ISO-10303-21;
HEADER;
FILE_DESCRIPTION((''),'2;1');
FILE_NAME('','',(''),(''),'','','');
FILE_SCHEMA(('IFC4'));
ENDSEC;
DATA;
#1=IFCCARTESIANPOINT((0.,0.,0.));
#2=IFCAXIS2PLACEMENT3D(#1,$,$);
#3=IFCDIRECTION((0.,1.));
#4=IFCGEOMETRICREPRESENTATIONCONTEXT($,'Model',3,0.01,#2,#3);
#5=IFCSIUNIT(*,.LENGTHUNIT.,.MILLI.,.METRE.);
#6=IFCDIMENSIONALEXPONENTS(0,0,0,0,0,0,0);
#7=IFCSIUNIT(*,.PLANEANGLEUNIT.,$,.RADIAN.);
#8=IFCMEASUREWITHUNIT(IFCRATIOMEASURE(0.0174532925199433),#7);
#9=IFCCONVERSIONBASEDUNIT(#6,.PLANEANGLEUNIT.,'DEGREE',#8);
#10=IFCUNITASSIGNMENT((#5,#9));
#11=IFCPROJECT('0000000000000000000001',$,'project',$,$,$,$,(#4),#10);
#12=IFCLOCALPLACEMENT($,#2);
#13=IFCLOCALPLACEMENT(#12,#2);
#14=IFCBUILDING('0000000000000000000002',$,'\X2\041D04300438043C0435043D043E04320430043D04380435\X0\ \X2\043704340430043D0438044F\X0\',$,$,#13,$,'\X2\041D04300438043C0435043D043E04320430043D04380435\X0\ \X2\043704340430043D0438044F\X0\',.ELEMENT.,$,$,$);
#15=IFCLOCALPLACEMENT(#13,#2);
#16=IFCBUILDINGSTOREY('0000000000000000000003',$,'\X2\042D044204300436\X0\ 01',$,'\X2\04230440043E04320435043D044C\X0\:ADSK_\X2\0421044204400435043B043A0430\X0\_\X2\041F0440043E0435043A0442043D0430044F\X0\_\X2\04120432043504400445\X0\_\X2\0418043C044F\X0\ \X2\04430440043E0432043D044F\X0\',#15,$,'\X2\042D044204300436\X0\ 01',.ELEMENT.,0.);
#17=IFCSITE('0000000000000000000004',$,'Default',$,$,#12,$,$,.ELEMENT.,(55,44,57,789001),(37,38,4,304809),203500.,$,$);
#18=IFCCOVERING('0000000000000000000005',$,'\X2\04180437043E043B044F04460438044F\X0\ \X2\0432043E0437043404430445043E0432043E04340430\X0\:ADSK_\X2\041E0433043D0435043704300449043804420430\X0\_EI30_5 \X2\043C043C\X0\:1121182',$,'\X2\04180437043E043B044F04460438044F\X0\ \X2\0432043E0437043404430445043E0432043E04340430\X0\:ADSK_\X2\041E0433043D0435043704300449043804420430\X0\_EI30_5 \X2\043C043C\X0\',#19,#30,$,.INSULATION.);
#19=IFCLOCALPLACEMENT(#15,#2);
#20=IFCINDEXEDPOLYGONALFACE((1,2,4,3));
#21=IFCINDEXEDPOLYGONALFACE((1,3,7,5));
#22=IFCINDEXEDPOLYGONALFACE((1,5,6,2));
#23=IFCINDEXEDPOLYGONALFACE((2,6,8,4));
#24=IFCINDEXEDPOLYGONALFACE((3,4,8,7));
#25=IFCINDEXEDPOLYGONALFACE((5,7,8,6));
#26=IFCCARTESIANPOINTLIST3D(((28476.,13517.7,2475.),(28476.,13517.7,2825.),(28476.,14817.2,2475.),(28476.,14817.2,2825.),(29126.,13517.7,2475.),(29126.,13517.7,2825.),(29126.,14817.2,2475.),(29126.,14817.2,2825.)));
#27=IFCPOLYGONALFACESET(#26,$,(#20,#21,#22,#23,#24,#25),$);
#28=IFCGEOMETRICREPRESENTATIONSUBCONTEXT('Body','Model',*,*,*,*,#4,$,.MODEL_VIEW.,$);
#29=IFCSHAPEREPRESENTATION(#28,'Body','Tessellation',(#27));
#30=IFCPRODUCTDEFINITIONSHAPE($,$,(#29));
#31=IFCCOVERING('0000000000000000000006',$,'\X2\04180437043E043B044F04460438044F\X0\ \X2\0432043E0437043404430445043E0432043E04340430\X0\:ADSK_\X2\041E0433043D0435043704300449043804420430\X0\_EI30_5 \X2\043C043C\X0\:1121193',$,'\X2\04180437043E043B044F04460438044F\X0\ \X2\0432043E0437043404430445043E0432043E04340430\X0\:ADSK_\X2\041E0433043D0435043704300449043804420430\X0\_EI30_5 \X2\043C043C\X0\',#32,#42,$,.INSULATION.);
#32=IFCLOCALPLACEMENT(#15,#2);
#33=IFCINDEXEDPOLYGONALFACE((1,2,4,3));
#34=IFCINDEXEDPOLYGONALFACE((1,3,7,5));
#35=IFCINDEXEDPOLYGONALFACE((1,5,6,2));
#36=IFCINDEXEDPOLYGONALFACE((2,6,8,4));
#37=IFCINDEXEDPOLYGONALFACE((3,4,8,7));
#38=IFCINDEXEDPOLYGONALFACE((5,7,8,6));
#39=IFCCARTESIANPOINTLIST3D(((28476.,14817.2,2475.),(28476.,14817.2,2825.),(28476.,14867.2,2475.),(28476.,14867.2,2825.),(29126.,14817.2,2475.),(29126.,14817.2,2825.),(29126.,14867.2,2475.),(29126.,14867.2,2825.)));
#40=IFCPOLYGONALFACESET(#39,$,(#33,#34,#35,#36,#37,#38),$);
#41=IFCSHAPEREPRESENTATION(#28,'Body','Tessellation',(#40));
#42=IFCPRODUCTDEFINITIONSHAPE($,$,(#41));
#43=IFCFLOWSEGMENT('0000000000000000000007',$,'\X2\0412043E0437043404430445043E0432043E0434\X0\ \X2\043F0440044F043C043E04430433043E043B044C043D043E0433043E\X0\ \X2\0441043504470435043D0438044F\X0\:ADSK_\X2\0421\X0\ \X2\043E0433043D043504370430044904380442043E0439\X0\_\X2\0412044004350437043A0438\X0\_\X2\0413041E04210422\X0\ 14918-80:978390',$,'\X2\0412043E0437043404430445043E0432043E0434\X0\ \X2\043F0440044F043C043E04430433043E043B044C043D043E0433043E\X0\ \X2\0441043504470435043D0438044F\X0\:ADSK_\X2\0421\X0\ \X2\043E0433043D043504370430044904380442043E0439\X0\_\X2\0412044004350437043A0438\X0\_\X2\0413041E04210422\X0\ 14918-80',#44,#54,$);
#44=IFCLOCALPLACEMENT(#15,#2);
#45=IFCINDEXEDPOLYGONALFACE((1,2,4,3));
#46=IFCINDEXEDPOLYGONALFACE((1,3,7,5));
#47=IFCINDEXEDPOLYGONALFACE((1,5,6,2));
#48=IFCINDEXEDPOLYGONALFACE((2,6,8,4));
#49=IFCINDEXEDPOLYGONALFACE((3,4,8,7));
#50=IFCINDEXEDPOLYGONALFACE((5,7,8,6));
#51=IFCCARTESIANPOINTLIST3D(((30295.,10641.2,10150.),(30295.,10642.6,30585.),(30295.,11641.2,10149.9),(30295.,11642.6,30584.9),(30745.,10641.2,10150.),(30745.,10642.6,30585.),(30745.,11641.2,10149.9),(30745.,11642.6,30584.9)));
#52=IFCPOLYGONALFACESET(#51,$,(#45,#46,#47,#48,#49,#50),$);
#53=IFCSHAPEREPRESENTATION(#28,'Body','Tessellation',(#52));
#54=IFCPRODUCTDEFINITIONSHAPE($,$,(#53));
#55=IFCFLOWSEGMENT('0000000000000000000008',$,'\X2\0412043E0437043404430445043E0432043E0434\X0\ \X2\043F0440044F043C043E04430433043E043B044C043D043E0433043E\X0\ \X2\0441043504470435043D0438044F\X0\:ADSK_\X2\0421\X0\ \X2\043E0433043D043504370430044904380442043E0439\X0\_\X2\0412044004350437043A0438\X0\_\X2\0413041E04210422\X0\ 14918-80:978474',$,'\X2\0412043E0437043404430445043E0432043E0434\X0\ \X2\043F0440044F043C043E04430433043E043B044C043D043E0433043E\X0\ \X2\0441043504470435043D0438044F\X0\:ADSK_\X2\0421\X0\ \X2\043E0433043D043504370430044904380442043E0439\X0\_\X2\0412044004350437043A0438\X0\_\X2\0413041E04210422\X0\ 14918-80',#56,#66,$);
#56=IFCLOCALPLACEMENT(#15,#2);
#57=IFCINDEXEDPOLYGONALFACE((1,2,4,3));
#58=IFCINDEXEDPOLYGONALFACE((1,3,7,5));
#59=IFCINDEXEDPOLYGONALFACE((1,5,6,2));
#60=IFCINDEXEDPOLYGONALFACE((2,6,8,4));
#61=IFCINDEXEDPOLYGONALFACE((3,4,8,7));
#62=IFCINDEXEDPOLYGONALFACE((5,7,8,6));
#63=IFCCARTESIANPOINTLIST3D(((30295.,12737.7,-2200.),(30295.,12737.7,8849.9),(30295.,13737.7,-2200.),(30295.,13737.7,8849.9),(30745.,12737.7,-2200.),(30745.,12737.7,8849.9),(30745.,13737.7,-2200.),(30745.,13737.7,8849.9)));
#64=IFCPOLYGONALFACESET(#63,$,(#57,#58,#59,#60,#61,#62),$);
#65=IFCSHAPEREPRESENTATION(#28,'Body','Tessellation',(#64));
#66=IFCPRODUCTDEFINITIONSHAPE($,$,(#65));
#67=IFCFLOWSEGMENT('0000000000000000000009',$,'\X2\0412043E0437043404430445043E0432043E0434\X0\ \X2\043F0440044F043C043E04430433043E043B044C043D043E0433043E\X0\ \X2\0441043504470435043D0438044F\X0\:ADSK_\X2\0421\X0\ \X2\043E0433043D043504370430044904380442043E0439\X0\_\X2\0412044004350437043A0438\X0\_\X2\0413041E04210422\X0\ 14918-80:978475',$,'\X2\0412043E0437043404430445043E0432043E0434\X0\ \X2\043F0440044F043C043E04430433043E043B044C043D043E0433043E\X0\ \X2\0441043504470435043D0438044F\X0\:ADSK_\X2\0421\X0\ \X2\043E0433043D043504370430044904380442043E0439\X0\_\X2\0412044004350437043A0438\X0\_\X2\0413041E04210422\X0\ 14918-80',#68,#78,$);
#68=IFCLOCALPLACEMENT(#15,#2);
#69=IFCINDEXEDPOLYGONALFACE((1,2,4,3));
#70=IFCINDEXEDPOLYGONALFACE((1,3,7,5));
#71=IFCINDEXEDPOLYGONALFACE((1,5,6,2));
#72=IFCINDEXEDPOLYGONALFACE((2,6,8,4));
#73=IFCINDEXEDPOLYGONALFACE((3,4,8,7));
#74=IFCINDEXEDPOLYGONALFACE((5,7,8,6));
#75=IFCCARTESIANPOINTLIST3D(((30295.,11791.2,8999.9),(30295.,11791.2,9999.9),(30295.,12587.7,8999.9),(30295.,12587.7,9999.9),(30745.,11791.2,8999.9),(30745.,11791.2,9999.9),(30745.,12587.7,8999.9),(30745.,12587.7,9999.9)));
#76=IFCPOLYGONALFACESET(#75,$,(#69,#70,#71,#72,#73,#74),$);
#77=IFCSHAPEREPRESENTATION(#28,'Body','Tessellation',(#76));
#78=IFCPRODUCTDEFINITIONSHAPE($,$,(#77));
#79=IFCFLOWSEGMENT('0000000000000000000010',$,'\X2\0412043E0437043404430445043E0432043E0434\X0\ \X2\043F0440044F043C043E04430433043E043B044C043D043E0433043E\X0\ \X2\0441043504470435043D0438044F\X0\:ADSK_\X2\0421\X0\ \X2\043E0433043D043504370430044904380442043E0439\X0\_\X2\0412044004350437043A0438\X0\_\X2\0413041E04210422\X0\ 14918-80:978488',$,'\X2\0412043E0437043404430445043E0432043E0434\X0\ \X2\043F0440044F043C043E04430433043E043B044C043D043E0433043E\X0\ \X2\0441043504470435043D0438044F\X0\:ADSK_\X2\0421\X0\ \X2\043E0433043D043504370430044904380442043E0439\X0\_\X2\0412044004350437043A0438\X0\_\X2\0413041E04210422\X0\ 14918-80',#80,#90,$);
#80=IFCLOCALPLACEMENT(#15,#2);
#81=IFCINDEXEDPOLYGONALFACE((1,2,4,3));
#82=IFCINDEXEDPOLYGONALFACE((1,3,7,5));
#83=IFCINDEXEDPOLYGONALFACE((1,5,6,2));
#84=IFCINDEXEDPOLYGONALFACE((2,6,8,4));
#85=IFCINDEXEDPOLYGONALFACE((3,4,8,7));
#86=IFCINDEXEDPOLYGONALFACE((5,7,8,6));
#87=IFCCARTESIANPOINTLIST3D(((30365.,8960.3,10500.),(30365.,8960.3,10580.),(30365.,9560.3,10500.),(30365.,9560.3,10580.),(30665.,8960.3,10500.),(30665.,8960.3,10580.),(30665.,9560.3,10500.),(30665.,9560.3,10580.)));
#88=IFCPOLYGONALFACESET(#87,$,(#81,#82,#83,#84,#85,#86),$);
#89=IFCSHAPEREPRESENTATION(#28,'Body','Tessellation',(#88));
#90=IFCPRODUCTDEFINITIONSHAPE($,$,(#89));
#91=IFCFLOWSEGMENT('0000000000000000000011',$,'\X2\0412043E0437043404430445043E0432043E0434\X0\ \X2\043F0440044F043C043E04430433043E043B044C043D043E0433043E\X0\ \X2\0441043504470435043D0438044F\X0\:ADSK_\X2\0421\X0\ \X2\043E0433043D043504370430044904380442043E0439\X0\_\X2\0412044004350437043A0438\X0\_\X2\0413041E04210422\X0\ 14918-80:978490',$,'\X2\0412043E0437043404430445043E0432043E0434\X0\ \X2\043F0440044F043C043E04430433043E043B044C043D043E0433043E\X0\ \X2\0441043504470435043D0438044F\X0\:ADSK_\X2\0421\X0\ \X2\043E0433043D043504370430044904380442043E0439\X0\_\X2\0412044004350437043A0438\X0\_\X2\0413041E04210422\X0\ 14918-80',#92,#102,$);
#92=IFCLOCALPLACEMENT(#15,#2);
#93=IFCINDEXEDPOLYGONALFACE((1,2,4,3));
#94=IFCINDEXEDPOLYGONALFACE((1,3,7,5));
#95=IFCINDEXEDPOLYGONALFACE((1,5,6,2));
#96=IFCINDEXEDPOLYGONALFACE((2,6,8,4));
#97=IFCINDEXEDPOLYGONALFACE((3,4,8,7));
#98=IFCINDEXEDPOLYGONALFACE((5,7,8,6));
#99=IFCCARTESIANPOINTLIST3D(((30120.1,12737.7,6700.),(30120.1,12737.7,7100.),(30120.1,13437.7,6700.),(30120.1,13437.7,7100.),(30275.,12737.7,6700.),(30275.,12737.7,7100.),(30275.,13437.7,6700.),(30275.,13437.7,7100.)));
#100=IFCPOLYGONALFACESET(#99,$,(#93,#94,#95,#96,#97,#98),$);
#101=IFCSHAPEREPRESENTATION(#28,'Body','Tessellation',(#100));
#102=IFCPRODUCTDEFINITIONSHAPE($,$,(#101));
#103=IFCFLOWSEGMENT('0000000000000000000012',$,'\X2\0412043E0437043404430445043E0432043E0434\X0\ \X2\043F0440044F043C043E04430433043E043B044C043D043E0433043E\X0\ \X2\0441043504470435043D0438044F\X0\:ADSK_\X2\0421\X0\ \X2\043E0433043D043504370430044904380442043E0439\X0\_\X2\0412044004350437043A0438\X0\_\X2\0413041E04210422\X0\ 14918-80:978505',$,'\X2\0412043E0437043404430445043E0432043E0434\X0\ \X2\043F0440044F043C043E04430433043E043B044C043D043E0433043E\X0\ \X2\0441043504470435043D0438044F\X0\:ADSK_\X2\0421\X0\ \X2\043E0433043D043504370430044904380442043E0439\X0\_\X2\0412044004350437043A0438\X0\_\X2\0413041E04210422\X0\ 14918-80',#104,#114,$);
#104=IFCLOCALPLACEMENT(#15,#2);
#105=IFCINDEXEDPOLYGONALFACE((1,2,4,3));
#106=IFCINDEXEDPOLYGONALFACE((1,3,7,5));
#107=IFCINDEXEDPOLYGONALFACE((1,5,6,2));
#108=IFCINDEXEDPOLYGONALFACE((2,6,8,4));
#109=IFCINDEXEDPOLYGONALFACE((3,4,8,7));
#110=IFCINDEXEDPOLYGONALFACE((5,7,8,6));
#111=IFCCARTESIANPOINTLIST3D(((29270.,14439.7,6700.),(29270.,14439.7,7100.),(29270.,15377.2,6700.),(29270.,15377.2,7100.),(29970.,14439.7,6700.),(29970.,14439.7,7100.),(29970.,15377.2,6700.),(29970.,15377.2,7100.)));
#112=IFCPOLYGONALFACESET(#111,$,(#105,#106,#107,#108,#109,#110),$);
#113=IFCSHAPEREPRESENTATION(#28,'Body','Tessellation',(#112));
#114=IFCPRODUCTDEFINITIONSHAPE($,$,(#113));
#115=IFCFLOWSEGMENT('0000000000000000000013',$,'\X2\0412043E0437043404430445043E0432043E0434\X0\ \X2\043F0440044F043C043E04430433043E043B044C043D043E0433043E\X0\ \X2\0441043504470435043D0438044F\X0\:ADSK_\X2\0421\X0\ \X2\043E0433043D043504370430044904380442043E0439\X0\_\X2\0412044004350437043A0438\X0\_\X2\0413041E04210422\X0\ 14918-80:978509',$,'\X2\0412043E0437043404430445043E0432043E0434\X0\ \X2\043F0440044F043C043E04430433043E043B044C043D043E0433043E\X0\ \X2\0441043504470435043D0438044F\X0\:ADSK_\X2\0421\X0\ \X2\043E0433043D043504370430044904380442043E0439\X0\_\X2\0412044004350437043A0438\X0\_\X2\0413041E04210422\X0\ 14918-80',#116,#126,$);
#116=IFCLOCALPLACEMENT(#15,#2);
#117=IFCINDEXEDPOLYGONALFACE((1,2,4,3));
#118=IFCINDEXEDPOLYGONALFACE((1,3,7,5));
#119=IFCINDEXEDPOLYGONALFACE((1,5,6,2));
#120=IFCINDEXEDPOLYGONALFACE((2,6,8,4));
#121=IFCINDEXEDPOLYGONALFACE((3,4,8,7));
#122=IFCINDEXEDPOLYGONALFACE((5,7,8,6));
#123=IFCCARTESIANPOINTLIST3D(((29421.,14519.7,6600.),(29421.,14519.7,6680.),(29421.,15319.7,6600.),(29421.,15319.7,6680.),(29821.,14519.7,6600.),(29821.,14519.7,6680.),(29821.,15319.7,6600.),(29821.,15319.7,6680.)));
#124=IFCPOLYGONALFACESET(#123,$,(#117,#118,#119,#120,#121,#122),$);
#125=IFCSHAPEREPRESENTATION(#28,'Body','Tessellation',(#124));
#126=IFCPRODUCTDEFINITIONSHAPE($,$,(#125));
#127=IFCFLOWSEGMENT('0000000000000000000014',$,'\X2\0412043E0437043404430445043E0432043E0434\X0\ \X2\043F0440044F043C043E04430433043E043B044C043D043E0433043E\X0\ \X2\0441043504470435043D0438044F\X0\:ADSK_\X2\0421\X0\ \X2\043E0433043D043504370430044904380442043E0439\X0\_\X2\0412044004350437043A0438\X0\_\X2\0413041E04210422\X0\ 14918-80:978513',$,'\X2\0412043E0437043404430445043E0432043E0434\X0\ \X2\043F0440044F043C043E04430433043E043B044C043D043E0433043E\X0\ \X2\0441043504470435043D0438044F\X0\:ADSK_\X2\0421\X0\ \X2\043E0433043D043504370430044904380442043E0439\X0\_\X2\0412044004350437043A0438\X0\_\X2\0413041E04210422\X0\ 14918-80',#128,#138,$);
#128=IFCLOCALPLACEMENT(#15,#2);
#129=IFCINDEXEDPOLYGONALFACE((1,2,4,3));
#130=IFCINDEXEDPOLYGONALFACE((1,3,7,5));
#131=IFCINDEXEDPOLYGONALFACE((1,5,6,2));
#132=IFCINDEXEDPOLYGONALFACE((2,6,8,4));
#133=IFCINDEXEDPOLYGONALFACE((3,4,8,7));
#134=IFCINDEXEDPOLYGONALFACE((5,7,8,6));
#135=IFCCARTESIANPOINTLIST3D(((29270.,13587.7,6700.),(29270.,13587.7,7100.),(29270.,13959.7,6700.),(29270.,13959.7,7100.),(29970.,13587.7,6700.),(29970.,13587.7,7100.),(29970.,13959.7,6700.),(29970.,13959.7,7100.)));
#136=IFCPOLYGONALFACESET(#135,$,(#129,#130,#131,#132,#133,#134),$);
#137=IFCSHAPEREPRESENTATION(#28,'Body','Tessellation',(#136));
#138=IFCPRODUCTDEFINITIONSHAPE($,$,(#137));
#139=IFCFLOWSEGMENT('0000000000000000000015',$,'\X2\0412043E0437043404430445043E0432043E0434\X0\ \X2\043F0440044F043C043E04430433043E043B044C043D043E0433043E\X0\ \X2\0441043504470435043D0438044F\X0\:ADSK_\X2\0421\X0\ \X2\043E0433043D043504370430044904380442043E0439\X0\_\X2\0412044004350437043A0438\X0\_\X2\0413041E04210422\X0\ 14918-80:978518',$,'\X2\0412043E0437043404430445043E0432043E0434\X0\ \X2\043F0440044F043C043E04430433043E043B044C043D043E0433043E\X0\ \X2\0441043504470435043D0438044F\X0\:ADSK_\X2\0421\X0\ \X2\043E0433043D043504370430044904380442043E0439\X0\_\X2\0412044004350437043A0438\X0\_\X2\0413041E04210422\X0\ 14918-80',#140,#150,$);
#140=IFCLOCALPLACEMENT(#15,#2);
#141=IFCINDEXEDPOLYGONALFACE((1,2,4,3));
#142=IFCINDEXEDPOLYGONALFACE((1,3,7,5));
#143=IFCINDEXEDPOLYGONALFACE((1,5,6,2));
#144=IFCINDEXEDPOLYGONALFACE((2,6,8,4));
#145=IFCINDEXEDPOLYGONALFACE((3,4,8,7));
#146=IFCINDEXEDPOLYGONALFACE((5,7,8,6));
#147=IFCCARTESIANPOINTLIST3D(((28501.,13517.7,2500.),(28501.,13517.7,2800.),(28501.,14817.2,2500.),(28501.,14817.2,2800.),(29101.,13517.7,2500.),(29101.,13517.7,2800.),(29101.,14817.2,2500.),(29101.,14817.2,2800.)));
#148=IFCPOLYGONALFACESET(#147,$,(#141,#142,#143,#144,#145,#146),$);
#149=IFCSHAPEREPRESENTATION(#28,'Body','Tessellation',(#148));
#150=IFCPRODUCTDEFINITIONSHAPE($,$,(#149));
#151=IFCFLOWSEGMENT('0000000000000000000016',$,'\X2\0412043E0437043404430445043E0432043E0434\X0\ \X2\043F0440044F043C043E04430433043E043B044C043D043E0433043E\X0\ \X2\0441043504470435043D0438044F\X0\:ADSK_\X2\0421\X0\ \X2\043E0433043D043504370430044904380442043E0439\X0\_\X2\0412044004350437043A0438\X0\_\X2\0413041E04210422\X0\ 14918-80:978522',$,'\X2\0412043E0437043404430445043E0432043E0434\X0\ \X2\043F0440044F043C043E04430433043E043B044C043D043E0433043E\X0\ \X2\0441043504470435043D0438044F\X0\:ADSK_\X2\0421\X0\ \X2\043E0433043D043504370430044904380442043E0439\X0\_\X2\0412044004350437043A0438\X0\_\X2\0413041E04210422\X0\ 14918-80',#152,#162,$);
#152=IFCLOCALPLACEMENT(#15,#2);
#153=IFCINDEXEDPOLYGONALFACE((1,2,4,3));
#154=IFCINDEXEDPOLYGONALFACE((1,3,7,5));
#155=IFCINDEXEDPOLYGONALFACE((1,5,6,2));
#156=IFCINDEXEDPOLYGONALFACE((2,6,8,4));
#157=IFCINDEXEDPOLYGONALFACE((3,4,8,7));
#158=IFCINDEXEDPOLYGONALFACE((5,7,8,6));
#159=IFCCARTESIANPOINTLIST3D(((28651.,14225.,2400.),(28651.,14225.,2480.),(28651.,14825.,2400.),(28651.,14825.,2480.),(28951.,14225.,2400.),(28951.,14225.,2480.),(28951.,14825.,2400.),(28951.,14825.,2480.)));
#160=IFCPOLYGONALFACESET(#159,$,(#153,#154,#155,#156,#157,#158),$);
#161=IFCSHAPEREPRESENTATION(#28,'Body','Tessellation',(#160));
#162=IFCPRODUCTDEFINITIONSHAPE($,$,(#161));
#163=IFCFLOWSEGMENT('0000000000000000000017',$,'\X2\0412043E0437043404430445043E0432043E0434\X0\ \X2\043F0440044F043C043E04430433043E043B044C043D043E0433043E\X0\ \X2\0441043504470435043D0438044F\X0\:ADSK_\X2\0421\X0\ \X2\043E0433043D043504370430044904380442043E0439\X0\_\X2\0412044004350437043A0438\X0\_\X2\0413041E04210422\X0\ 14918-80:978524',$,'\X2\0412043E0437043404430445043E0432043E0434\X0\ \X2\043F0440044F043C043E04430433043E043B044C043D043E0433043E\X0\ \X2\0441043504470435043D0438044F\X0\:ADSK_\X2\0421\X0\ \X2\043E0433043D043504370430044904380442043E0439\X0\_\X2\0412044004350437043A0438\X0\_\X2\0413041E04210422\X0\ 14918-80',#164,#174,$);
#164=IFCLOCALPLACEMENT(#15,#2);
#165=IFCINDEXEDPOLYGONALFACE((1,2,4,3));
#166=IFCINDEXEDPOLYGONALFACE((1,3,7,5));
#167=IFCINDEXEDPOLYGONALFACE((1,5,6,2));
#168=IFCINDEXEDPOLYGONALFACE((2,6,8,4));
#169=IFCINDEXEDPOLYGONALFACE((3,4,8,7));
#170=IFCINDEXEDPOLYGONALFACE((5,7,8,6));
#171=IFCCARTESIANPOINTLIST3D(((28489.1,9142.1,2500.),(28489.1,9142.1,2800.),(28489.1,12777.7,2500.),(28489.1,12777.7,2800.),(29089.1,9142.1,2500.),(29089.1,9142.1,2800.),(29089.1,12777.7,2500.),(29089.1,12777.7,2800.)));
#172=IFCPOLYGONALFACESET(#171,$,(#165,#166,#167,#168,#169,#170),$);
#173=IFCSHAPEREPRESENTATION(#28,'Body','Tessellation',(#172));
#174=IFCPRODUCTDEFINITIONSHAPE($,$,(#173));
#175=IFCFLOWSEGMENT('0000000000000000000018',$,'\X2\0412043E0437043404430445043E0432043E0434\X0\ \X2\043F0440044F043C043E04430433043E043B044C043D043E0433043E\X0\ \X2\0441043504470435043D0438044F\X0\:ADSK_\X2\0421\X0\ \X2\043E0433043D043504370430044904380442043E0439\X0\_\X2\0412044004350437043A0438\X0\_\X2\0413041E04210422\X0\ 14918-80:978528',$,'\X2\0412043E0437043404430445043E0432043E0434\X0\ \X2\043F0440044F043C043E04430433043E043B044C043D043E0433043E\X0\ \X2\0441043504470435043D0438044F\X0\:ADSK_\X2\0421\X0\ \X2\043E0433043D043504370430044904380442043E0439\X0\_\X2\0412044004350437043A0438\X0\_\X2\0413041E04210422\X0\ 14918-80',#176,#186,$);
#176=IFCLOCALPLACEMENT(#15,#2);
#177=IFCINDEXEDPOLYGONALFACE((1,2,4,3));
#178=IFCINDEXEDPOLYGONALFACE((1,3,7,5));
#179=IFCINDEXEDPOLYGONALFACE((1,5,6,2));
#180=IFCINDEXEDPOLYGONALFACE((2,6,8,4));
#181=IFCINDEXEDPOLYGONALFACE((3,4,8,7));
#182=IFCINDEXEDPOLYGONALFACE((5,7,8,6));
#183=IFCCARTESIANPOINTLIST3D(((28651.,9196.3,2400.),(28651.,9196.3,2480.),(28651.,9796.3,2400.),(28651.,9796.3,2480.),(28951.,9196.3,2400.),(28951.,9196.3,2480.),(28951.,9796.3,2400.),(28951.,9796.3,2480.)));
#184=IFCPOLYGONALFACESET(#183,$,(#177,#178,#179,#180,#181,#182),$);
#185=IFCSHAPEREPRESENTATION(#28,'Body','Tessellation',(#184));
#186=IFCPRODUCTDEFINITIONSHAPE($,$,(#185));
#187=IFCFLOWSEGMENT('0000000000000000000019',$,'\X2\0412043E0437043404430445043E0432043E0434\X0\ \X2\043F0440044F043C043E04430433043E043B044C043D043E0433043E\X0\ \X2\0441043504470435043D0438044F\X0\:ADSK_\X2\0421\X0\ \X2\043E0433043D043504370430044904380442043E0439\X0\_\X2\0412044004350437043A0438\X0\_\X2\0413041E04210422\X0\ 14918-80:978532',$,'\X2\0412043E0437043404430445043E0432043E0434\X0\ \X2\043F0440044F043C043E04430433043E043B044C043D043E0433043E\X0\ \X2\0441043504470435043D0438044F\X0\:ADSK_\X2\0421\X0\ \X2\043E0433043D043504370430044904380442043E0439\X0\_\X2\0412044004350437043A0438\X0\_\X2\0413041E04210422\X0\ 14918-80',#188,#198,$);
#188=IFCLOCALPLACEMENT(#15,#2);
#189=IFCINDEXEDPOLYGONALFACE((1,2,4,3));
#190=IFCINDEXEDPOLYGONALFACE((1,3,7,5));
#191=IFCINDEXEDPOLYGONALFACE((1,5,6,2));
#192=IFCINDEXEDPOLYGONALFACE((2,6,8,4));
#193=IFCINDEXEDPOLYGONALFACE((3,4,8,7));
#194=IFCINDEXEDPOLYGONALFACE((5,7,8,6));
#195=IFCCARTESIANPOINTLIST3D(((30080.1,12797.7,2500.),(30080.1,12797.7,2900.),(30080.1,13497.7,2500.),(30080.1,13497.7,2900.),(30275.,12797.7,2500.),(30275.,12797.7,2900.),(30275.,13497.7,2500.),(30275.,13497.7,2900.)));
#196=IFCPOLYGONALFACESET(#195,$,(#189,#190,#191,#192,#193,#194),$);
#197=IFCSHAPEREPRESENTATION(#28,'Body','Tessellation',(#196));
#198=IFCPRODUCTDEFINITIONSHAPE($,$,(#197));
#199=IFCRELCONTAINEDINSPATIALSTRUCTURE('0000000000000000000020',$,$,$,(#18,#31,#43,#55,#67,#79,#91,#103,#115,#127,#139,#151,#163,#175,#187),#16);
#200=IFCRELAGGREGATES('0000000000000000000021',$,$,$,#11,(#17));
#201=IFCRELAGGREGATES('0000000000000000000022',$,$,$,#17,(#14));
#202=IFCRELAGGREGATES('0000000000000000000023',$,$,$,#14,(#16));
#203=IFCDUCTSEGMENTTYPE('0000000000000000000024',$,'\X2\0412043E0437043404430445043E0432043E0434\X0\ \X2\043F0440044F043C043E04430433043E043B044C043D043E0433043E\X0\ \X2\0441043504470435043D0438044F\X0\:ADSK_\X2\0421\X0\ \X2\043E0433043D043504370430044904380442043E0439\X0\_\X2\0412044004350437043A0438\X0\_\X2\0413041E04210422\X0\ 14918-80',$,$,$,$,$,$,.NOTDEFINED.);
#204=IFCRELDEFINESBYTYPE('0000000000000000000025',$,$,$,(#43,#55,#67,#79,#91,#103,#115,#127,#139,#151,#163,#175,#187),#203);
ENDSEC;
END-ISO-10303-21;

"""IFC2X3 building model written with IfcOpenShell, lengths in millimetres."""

from ifc_helpers import new_model, entity, si_unit, converted_unit, direction, frame, frame_2d, origin, origin_2d_with_axis, place, context, subcontext, project, spatial, rectangle, extrude, type_object, element, save


model = new_model("IFC2X3")

# Units and contexts
model_context = context("Model", 3, precision=0.01, world=origin(), true_north=direction((0.0, 1.0)))
body_context = subcontext(model_context, "Body", "Model", "MODEL_VIEW")
ifc_project = project(units=[si_unit("LENGTHUNIT", "METRE", prefix="MILLI"), converted_unit("PLANEANGLEUNIT", "DEGREE", entity("IfcRatioMeasure", 0.0174532925199433), si_unit("PLANEANGLEUNIT", "RADIAN"), dimensions=[0, 0, 0, 0, 0, 0, 0])], contexts=[model_context])

# Site, building, storey
site_placement = place(None, origin())
site = spatial("IfcSite", under=ifc_project, at=site_placement, Name="Default", CompositionType="ELEMENT", RefLatitude=(55, 44, 57, 789001), RefLongitude=(37, 38, 4, 304809), RefElevation=203500.0)
building_placement = place(site_placement, origin())
building = spatial("IfcBuilding", under=site, at=building_placement, Name="Наименование здания", LongName="Наименование здания", CompositionType="ELEMENT")
storey_placement = place(building_placement, origin())
storey = spatial("IfcBuildingStorey", under=building, at=storey_placement, Name="Этаж 01", ObjectType="Уровень:ADSK_Стрелка_Проектная_Вверх_Имя уровня", LongName="Этаж 01", CompositionType="ELEMENT", Elevation=0.0)

# Coverings
covering_1_placement = place(storey_placement, frame((28476.0, 13517.7, 2475.0)))
element("IfcCovering", 1, at=covering_1_placement, inside=storey, Name="Изоляция воздуховода:ADSK_Огнезащита_EI30_5 мм:1121182", ObjectType="Изоляция воздуховода:ADSK_Огнезащита_EI30_5 мм", PredefinedType="INSULATION", context=body_context, shape_type="SweptSolid", body=[
    extrude(rectangle(XDim=1299.5, YDim=650.0, at=origin_2d_with_axis()), frame((325.0, 649.8, 0.0), z_axis=(0.0, 0.0, 1.0), x_axis=(0.0, 1.0, 0.0)), (0.0, 0.0, 1.0), 350.0),
])
covering_2_placement = place(storey_placement, frame((28476.0, 14817.2, 2475.0)))
element("IfcCovering", 2, at=covering_2_placement, inside=storey, Name="Изоляция воздуховода:ADSK_Огнезащита_EI30_5 мм:1121193", ObjectType="Изоляция воздуховода:ADSK_Огнезащита_EI30_5 мм", PredefinedType="INSULATION", context=body_context, shape_type="SweptSolid", body=[
    extrude(rectangle(XDim=50.0, YDim=650.0, at=origin_2d_with_axis()), frame((325.0, 25.0, 0.0), z_axis=(0.0, 0.0, 1.0), x_axis=(0.0, -1.0, 0.0)), (0.0, 0.0, 1.0), 350.0),
])

# Flow segments
duct_segment_type = type_object("IfcDuctSegmentType", Name="Воздуховод прямоугольного сечения:ADSK_С огнезащитой_Врезки_ГОСТ 14918-80", PredefinedType="NOTDEFINED")
flow_segment_1_placement = place(storey_placement, frame((30295.0, 10641.2, 10149.9)))
element("IfcFlowSegment", 3, at=flow_segment_1_placement, inside=storey, type_object=duct_segment_type, Name="Воздуховод прямоугольного сечения:ADSK_С огнезащитой_Врезки_ГОСТ 14918-80:978390", ObjectType="Воздуховод прямоугольного сечения:ADSK_С огнезащитой_Врезки_ГОСТ 14918-80", context=body_context, shape_type="SweptSolid", body=[
    extrude(rectangle(XDim=1000.0, YDim=450.0, at=frame_2d((0.0, 0.0), x_axis=(0.0, 1.0))), frame((225.0, 500.0, 0.0), z_axis=(0.0, 0.000067, 1.0), x_axis=(1.0, 0.0, 0.0)), (0.0, 0.0, 1.0), 20435.0),
])
flow_segment_2_placement = place(storey_placement, frame((30295.0, 12737.7, -2200.0)))
element("IfcFlowSegment", 4, at=flow_segment_2_placement, inside=storey, type_object=duct_segment_type, Name="Воздуховод прямоугольного сечения:ADSK_С огнезащитой_Врезки_ГОСТ 14918-80:978474", ObjectType="Воздуховод прямоугольного сечения:ADSK_С огнезащитой_Врезки_ГОСТ 14918-80", context=body_context, shape_type="SweptSolid", body=[
    extrude(rectangle(XDim=1000.0, YDim=450.0, at=origin_2d_with_axis()), frame((225.0, 500.0, 0.0), z_axis=(0.0, 0.0, 1.0), x_axis=(0.0, 1.0, 0.0)), (0.0, 0.0, 1.0), 11049.9),
])
flow_segment_3_placement = place(storey_placement, frame((30295.0, 11791.2, 8999.9)))
element("IfcFlowSegment", 5, at=flow_segment_3_placement, inside=storey, type_object=duct_segment_type, Name="Воздуховод прямоугольного сечения:ADSK_С огнезащитой_Врезки_ГОСТ 14918-80:978475", ObjectType="Воздуховод прямоугольного сечения:ADSK_С огнезащитой_Врезки_ГОСТ 14918-80", context=body_context, shape_type="SweptSolid", body=[
    extrude(rectangle(XDim=796.6, YDim=450.0, at=origin_2d_with_axis()), frame((225.0, 398.3, 0.0), z_axis=(0.0, 0.0, 1.0), x_axis=(0.0, -1.0, 0.0)), (0.0, 0.0, 1.0), 1000.0),
])
flow_segment_4_placement = place(storey_placement, frame((30365.0, 8960.3, 10500.0)))
element("IfcFlowSegment", 6, at=flow_segment_4_placement, inside=storey, type_object=duct_segment_type, Name="Воздуховод прямоугольного сечения:ADSK_С огнезащитой_Врезки_ГОСТ 14918-80:978488", ObjectType="Воздуховод прямоугольного сечения:ADSK_С огнезащитой_Врезки_ГОСТ 14918-80", context=body_context, shape_type="SweptSolid", body=[
    extrude(rectangle(XDim=300.0, YDim=600.0, at=origin_2d_with_axis()), frame((150.0, 300.0, 0.0)), (0.0, 0.0, 1.0), 80.0),
])
flow_segment_5_placement = place(storey_placement, frame((30120.0, 12737.7, 6700.0)))
element("IfcFlowSegment", 7, at=flow_segment_5_placement, inside=storey, type_object=duct_segment_type, Name="Воздуховод прямоугольного сечения:ADSK_С огнезащитой_Врезки_ГОСТ 14918-80:978490", ObjectType="Воздуховод прямоугольного сечения:ADSK_С огнезащитой_Врезки_ГОСТ 14918-80", context=body_context, shape_type="SweptSolid", body=[
    extrude(rectangle(XDim=155.0, YDim=700.0, at=origin_2d_with_axis()), frame((77.5, 350.0, 0.0), z_axis=(0.0, 0.0, 1.0), x_axis=(-1.0, 0.0, 0.0)), (0.0, 0.0, 1.0), 400.0),
])
flow_segment_6_placement = place(storey_placement, frame((29270.0, 14439.7, 6700.0)))
element("IfcFlowSegment", 8, at=flow_segment_6_placement, inside=storey, type_object=duct_segment_type, Name="Воздуховод прямоугольного сечения:ADSK_С огнезащитой_Врезки_ГОСТ 14918-80:978505", ObjectType="Воздуховод прямоугольного сечения:ADSK_С огнезащитой_Врезки_ГОСТ 14918-80", context=body_context, shape_type="SweptSolid", body=[
    extrude(rectangle(XDim=937.5, YDim=700.0, at=origin_2d_with_axis()), frame((350.0, 468.8, 0.0), z_axis=(0.0, 0.0, 1.0), x_axis=(0.0, -1.0, 0.0)), (0.0, 0.0, 1.0), 400.0),
])
flow_segment_7_placement = place(storey_placement, frame((29421.0, 14519.7, 6600.0)))
element("IfcFlowSegment", 9, at=flow_segment_7_placement, inside=storey, type_object=duct_segment_type, Name="Воздуховод прямоугольного сечения:ADSK_С огнезащитой_Врезки_ГОСТ 14918-80:978509", ObjectType="Воздуховод прямоугольного сечения:ADSK_С огнезащитой_Врезки_ГОСТ 14918-80", context=body_context, shape_type="SweptSolid", body=[
    extrude(rectangle(XDim=800.0, YDim=400.0, at=origin_2d_with_axis()), frame((200.0, 400.0, 0.0), z_axis=(0.0, 0.0, 1.0), x_axis=(0.0, 1.0, 0.0)), (0.0, 0.0, 1.0), 80.0),
])
flow_segment_8_placement = place(storey_placement, frame((29270.0, 13587.7, 6700.0)))
element("IfcFlowSegment", 10, at=flow_segment_8_placement, inside=storey, type_object=duct_segment_type, Name="Воздуховод прямоугольного сечения:ADSK_С огнезащитой_Врезки_ГОСТ 14918-80:978513", ObjectType="Воздуховод прямоугольного сечения:ADSK_С огнезащитой_Врезки_ГОСТ 14918-80", context=body_context, shape_type="SweptSolid", body=[
    extrude(rectangle(XDim=372.0, YDim=700.0, at=origin_2d_with_axis()), frame((350.0, 186.0, 0.0), z_axis=(0.0, 0.0, 1.0), x_axis=(0.0, 1.0, 0.0)), (0.0, 0.0, 1.0), 400.0),
])
flow_segment_9_placement = place(storey_placement, frame((28501.0, 13517.7, 2500.0)))
element("IfcFlowSegment", 11, at=flow_segment_9_placement, inside=storey, type_object=duct_segment_type, Name="Воздуховод прямоугольного сечения:ADSK_С огнезащитой_Врезки_ГОСТ 14918-80:978518", ObjectType="Воздуховод прямоугольного сечения:ADSK_С огнезащитой_Врезки_ГОСТ 14918-80", context=body_context, shape_type="SweptSolid", body=[
    extrude(rectangle(XDim=1299.5, YDim=600.0, at=origin_2d_with_axis()), frame((300.0, 649.8, 0.0), z_axis=(0.0, 0.0, 1.0), x_axis=(0.0, 1.0, 0.0)), (0.0, 0.0, 1.0), 300.0),
])
flow_segment_10_placement = place(storey_placement, frame((28651.0, 14225.0, 2400.0)))
element("IfcFlowSegment", 12, at=flow_segment_10_placement, inside=storey, type_object=duct_segment_type, Name="Воздуховод прямоугольного сечения:ADSK_С огнезащитой_Врезки_ГОСТ 14918-80:978522", ObjectType="Воздуховод прямоугольного сечения:ADSK_С огнезащитой_Врезки_ГОСТ 14918-80", context=body_context, shape_type="SweptSolid", body=[
    extrude(rectangle(XDim=600.0, YDim=300.0, at=origin_2d_with_axis()), frame((150.0, 300.0, 0.0), z_axis=(0.0, 0.0, 1.0), x_axis=(0.0, 1.0, 0.0)), (0.0, 0.0, 1.0), 80.0),
])
flow_segment_11_placement = place(storey_placement, frame((28489.1, 9142.1, 2500.0)))
element("IfcFlowSegment", 13, at=flow_segment_11_placement, inside=storey, type_object=duct_segment_type, Name="Воздуховод прямоугольного сечения:ADSK_С огнезащитой_Врезки_ГОСТ 14918-80:978524", ObjectType="Воздуховод прямоугольного сечения:ADSK_С огнезащитой_Врезки_ГОСТ 14918-80", context=body_context, shape_type="SweptSolid", body=[
    extrude(rectangle(XDim=3635.6, YDim=600.0, at=origin_2d_with_axis()), frame((300.0, 1817.8, 0.0), z_axis=(0.0, 0.0, 1.0), x_axis=(0.0, -1.0, 0.0)), (0.0, 0.0, 1.0), 300.0),
])
flow_segment_12_placement = place(storey_placement, frame((28651.0, 9196.3, 2400.0)))
element("IfcFlowSegment", 14, at=flow_segment_12_placement, inside=storey, type_object=duct_segment_type, Name="Воздуховод прямоугольного сечения:ADSK_С огнезащитой_Врезки_ГОСТ 14918-80:978528", ObjectType="Воздуховод прямоугольного сечения:ADSK_С огнезащитой_Врезки_ГОСТ 14918-80", context=body_context, shape_type="SweptSolid", body=[
    extrude(rectangle(XDim=600.0, YDim=300.0, at=origin_2d_with_axis()), frame((150.0, 300.0, 0.0), z_axis=(0.0, 0.0, 1.0), x_axis=(0.0, 1.0, 0.0)), (0.0, 0.0, 1.0), 80.0),
])
flow_segment_13_placement = place(storey_placement, frame((30080.1, 12797.7, 2500.0)))
element("IfcFlowSegment", 15, at=flow_segment_13_placement, inside=storey, type_object=duct_segment_type, Name="Воздуховод прямоугольного сечения:ADSK_С огнезащитой_Врезки_ГОСТ 14918-80:978532", ObjectType="Воздуховод прямоугольного сечения:ADSK_С огнезащитой_Врезки_ГОСТ 14918-80", context=body_context, shape_type="SweptSolid", body=[
    extrude(rectangle(XDim=194.9, YDim=700.0, at=origin_2d_with_axis()), frame((97.5, 350.0, 0.0), z_axis=(0.0, 0.0, 1.0), x_axis=(-1.0, 0.0, 0.0)), (0.0, 0.0, 1.0), 400.0),
])

save(model, "model.ifc")
